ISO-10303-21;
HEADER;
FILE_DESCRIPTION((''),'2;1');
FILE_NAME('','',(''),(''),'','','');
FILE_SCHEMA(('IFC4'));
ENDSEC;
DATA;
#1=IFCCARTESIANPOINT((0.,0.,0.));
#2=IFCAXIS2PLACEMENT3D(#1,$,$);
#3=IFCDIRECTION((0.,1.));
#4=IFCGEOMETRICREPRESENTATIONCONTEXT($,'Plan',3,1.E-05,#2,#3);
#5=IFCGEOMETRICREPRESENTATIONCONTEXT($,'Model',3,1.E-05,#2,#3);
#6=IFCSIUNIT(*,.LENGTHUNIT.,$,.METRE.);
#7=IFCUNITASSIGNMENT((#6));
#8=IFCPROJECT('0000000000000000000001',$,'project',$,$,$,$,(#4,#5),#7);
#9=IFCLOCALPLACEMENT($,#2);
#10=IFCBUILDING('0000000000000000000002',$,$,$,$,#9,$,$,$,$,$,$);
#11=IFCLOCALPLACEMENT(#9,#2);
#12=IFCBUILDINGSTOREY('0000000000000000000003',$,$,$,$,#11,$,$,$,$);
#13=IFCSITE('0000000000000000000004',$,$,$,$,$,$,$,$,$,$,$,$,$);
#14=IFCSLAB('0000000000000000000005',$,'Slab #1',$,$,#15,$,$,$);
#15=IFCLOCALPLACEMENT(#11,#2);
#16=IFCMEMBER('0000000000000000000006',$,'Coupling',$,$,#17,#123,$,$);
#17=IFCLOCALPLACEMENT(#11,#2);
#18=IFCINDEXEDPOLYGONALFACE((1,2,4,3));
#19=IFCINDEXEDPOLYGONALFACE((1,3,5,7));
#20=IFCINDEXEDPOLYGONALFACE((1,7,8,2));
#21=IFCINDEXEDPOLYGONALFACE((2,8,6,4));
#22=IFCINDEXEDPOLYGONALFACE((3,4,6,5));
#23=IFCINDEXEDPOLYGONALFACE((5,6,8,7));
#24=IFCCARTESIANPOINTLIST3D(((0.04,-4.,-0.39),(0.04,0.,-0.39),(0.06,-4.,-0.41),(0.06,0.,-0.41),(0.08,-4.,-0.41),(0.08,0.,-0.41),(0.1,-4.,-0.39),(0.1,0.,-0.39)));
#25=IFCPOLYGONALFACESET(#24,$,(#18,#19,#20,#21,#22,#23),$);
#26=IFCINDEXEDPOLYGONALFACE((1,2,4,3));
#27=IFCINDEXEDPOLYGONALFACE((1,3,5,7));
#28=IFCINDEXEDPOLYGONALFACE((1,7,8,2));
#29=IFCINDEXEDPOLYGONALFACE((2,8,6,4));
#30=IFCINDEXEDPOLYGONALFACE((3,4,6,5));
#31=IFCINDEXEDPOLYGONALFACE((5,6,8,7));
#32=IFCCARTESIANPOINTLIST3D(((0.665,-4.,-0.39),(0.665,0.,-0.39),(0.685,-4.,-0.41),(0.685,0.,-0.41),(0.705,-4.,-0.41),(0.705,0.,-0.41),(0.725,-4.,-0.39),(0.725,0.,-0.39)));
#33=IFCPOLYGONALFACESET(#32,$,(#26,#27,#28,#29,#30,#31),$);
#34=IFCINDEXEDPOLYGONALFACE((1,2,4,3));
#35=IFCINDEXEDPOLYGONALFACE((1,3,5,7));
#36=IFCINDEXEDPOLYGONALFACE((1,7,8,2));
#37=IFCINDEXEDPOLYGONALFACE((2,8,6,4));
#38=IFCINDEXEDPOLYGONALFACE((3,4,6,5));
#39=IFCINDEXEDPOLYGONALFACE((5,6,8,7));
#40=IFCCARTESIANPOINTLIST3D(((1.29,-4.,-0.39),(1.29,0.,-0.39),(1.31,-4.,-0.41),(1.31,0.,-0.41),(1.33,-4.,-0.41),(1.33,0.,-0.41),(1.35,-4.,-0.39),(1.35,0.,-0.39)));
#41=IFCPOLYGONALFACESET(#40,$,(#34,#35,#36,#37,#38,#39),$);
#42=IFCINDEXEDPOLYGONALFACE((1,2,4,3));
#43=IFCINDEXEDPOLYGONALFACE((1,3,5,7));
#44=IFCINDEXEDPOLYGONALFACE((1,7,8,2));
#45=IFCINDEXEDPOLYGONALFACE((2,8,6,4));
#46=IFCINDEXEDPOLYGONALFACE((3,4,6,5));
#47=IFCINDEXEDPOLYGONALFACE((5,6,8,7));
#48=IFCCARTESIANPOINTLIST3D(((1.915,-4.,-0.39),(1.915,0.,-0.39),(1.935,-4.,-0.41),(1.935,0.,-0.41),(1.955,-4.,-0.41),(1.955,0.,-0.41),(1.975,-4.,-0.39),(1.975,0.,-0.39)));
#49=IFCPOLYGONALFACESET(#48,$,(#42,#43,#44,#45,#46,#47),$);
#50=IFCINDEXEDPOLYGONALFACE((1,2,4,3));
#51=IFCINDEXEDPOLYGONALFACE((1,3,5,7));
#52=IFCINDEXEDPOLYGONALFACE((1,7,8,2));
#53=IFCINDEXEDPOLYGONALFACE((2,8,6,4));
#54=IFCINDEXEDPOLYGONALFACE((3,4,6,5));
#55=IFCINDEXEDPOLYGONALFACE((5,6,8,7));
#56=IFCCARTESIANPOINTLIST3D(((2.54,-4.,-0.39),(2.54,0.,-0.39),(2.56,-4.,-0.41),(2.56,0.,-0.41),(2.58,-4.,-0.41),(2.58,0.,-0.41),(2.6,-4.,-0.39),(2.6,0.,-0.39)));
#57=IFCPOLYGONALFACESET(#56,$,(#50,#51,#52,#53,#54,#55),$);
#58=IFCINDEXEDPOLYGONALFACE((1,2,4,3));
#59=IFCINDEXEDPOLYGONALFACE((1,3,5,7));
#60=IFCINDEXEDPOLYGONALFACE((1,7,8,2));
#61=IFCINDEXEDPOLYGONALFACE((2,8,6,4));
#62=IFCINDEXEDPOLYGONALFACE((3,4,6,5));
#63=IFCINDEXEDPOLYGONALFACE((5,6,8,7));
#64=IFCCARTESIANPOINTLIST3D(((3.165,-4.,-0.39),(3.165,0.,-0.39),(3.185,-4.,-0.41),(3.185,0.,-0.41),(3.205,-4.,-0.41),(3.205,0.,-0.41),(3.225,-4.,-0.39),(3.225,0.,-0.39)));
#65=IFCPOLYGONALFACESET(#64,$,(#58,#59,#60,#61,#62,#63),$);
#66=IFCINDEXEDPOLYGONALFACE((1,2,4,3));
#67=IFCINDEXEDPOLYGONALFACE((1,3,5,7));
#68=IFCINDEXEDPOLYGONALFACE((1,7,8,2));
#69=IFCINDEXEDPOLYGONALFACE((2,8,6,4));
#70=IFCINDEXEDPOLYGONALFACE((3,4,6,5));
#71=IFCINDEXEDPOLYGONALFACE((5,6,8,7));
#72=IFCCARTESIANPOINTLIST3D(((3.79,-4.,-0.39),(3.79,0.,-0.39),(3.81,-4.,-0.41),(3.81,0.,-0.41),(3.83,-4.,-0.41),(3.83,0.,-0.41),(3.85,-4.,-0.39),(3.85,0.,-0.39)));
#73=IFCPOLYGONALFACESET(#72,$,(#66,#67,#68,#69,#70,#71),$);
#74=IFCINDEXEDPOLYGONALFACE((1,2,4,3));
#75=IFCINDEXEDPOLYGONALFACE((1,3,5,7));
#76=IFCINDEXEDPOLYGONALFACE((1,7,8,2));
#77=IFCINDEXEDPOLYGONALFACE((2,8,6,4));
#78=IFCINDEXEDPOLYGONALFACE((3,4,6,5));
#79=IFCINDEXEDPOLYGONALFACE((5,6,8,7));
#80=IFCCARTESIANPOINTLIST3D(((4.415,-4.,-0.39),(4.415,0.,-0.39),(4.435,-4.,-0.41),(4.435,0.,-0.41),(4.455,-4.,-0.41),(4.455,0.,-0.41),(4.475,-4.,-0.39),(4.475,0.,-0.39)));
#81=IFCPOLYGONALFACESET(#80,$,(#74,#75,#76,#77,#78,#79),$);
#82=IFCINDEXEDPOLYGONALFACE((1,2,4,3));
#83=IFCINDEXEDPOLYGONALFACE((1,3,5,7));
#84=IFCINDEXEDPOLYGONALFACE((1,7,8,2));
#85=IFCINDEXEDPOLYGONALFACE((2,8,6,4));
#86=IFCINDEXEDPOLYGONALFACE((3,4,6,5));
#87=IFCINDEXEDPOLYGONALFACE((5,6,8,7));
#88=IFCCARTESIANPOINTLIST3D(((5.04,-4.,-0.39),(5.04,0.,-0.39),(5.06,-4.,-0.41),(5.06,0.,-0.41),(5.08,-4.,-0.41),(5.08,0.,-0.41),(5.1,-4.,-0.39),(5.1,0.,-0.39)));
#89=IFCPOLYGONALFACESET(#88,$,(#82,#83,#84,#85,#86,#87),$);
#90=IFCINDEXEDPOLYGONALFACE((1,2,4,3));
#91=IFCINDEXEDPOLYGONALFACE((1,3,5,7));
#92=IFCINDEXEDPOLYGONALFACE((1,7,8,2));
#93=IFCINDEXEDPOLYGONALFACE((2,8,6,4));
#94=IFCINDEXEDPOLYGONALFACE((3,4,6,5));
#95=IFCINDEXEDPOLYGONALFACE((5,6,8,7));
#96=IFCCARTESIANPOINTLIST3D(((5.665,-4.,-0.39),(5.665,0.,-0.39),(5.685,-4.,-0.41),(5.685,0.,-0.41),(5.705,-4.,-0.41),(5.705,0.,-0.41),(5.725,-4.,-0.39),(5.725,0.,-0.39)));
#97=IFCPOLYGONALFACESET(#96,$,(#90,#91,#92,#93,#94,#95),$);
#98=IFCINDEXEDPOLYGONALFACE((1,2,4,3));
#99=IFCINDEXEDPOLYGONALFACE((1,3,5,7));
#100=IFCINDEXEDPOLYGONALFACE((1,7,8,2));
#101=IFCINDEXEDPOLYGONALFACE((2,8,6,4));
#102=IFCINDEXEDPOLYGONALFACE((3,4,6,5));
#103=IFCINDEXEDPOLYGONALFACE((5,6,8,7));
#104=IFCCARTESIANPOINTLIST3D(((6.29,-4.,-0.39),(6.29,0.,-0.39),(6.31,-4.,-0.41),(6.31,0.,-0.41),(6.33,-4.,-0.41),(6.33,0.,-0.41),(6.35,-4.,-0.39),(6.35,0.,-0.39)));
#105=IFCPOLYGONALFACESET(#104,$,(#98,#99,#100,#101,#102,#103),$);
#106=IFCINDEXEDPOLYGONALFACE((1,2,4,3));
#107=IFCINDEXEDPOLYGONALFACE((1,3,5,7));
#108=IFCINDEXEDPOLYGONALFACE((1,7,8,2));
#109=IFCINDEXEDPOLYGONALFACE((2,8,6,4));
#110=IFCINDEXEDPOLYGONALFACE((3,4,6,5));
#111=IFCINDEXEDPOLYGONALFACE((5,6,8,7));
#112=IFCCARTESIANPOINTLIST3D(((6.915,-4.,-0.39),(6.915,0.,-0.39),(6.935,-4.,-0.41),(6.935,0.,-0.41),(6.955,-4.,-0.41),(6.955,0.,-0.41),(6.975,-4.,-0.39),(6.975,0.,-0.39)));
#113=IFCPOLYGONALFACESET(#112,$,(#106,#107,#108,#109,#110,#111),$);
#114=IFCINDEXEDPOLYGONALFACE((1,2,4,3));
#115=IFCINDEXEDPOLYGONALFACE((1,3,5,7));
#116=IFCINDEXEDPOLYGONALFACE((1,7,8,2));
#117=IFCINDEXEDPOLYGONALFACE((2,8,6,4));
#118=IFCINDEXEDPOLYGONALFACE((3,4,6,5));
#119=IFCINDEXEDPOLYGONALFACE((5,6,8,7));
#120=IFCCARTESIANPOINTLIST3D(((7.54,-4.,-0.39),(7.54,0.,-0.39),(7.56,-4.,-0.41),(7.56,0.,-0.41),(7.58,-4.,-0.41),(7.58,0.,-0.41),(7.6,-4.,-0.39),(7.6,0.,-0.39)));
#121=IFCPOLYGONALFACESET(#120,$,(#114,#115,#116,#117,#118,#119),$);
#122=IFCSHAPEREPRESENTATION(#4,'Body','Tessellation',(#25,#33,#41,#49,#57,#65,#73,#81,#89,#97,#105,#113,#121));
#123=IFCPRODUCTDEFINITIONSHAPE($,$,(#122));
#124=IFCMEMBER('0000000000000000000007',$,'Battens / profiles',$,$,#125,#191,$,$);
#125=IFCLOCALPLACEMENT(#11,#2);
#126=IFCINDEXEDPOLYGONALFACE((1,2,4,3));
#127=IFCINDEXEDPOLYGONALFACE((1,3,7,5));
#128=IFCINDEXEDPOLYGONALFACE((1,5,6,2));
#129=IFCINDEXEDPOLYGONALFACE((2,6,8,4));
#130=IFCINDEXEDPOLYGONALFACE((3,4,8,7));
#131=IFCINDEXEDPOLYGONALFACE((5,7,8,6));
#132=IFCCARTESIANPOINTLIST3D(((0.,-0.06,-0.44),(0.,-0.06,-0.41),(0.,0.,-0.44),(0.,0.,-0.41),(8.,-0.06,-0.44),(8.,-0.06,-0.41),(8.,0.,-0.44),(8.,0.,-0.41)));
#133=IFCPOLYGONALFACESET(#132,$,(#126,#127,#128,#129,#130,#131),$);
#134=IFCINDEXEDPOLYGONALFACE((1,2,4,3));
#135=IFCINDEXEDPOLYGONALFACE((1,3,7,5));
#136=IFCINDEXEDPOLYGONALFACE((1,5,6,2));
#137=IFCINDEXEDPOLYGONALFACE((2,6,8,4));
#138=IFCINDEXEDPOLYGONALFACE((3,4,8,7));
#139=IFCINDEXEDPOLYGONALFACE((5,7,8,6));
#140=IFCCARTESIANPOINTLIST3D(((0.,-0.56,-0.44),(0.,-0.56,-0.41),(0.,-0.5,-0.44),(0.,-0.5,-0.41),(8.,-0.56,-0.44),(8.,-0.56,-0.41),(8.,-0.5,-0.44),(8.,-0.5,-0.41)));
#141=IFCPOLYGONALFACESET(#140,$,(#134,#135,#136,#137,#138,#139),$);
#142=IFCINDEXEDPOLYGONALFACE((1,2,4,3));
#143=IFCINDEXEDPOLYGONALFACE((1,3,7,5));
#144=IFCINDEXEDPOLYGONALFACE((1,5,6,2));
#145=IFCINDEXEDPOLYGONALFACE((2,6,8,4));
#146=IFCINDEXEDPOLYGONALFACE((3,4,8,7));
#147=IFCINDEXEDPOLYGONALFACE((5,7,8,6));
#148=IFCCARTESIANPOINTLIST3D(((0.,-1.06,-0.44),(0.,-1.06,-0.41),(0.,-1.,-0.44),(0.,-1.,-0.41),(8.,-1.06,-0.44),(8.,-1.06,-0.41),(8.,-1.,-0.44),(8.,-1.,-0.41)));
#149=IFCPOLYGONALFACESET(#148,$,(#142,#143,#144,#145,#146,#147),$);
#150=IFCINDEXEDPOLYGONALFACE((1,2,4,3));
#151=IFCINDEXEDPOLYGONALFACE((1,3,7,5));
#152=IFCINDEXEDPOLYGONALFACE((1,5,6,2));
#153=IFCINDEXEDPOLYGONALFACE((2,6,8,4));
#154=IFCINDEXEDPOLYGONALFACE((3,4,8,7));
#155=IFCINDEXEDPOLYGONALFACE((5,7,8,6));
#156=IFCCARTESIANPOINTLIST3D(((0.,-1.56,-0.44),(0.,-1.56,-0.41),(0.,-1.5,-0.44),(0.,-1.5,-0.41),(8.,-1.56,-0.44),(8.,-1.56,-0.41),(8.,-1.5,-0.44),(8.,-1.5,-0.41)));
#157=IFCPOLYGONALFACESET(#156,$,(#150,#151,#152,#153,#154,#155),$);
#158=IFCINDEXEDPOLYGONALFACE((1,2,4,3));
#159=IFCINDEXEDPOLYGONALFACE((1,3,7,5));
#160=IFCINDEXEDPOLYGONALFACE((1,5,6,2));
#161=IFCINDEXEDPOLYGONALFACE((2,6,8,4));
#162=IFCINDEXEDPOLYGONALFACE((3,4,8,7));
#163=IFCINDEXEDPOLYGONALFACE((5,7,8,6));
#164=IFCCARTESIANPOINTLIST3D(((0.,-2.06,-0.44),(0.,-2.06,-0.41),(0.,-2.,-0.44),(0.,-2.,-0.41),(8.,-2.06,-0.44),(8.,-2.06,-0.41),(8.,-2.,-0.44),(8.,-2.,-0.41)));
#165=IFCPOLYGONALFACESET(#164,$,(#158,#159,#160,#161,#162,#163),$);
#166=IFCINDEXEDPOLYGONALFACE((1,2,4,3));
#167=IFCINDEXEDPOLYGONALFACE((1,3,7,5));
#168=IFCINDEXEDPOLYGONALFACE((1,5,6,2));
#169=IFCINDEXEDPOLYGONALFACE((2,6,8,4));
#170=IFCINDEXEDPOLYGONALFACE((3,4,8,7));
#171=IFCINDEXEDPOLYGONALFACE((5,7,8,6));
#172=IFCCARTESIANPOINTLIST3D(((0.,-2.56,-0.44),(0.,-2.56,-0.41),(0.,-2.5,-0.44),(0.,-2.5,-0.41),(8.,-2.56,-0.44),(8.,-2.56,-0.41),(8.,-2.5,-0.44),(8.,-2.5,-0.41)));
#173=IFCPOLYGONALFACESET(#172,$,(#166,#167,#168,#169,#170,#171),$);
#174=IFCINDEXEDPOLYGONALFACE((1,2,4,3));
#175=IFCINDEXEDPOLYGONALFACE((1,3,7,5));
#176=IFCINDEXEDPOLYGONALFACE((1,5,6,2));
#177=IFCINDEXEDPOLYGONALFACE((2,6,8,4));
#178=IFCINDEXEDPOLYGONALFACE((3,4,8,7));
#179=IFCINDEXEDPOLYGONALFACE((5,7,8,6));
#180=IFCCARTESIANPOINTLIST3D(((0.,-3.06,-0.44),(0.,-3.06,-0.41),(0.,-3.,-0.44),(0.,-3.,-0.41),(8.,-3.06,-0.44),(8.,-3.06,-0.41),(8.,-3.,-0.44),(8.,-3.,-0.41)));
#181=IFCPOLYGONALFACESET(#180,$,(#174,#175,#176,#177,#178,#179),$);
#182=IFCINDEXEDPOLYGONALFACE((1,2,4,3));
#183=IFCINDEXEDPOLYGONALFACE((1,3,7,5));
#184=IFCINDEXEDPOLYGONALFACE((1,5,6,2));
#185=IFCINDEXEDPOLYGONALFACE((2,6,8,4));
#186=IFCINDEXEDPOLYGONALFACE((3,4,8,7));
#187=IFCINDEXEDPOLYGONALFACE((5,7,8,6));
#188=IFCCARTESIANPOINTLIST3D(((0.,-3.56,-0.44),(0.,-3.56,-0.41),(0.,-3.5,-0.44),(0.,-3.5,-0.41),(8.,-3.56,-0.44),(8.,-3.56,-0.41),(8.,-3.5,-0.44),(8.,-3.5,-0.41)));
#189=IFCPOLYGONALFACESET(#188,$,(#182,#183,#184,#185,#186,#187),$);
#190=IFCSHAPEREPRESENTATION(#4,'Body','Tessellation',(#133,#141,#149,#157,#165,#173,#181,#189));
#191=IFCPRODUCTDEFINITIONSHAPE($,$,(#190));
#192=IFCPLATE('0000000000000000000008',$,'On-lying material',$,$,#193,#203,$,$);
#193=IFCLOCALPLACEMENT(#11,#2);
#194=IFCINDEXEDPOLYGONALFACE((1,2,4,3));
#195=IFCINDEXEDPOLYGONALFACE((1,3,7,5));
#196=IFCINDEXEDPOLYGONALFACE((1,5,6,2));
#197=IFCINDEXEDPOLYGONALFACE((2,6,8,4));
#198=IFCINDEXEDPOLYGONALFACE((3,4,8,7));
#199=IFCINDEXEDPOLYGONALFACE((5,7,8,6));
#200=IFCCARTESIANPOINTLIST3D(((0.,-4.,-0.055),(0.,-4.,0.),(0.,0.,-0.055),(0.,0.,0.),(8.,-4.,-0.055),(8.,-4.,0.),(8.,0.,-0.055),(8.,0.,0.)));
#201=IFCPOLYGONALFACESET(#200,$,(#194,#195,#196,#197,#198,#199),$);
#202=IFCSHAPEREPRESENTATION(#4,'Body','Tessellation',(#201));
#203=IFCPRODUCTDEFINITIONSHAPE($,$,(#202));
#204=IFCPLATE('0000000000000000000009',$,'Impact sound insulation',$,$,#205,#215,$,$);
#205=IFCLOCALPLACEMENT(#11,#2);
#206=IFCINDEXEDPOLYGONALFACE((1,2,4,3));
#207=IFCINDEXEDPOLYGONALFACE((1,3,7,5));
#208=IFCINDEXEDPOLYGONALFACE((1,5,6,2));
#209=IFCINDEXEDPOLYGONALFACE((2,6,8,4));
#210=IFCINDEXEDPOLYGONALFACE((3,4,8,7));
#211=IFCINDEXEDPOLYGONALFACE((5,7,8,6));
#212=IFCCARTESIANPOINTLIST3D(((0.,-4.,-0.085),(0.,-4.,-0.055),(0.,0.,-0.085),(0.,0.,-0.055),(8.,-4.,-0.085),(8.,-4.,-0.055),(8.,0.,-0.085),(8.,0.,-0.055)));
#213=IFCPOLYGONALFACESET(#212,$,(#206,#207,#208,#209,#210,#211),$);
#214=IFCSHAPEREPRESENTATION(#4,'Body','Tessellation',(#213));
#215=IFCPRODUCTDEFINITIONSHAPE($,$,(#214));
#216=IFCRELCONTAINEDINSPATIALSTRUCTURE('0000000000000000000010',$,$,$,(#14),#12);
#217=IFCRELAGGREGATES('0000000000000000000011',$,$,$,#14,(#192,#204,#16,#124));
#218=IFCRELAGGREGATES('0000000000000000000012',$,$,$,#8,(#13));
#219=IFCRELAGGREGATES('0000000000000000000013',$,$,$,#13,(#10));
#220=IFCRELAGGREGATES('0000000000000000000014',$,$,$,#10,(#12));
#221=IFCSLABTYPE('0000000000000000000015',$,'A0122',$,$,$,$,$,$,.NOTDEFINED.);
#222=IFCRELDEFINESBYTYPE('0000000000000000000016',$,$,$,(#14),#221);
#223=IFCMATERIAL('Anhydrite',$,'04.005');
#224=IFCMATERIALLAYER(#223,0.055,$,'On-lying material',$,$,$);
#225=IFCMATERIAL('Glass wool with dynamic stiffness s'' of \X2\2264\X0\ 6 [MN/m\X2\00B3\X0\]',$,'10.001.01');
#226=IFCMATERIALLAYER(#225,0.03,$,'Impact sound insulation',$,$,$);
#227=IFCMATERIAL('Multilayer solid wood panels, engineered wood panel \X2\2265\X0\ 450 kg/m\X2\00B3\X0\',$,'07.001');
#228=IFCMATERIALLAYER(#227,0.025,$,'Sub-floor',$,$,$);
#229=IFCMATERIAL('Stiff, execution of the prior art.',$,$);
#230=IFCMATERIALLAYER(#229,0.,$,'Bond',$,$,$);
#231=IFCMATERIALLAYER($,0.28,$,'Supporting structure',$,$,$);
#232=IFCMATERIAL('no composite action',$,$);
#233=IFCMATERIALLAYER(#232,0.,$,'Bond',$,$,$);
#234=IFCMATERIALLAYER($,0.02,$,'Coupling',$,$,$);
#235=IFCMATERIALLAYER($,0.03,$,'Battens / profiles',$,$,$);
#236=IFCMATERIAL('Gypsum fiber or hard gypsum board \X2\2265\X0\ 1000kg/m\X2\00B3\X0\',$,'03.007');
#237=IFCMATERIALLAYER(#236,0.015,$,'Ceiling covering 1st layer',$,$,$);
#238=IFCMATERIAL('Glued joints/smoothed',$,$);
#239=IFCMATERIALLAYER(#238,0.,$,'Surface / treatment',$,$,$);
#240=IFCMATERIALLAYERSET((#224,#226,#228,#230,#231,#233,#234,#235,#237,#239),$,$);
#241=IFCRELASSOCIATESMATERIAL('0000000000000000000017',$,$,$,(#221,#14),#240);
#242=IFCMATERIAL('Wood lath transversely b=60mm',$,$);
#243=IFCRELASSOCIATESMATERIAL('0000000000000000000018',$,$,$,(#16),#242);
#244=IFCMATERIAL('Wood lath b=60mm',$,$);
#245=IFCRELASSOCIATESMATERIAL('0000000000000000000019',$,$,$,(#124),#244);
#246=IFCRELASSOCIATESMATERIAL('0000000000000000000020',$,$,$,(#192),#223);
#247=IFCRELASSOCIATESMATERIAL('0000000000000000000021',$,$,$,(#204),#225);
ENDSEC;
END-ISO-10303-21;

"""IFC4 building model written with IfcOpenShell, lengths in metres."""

from ifc_helpers import new_model, si_unit, direction, frame, frame_2d, origin, origin_with_axes, place, context, project, spatial, polyline, rectangle, outline, extrude, material, layer, layer_set, type_object, element, aggregate, save


model = new_model("IFC4")

# Units and contexts
plan_context = context("Plan", 3, precision=1e-05, world=origin(), true_north=direction((0.0, 1.0)))
model_context = context("Model", 3, precision=1e-05, world=origin(), true_north=direction((0.0, 1.0)))
ifc_project = project(units=[si_unit("LENGTHUNIT", "METRE")], contexts=[plan_context, model_context])

# Site, building, storey
site = spatial("IfcSite", under=ifc_project)
building_placement = place(None, origin())
building = spatial("IfcBuilding", under=site, at=building_placement)
storey_placement = place(building_placement, origin())
storey = spatial("IfcBuildingStorey", under=building, at=storey_placement)

# Slab, members, plates
ifc_material_1 = material(Name="Anhydrite", Category="04.005")
ifc_layer_1 = layer(ifc_material_1, 0.055, Name="On-lying material")
ifc_material_2 = material(Name="Glass wool with dynamic stiffness s' of ≤ 6 [MN/m³]", Category="10.001.01")
ifc_layer_2 = layer(ifc_material_2, 0.03, Name="Impact sound insulation")
ifc_material_3 = material(Name="Multilayer solid wood panels, engineered wood panel ≥ 450 kg/m³", Category="07.001")
ifc_layer_3 = layer(ifc_material_3, 0.025, Name="Sub-floor")
ifc_material_4 = material(Name="Stiff, execution of the prior art.")
ifc_layer_4 = layer(ifc_material_4, 0.0, Name="Bond")
ifc_layer_5 = layer(None, 0.28, Name="Supporting structure")
ifc_material_5 = material(Name="no composite action")
ifc_layer_6 = layer(ifc_material_5, 0.0, Name="Bond")
ifc_layer_7 = layer(None, 0.02, Name="Coupling")
ifc_layer_8 = layer(None, 0.03, Name="Battens / profiles")
ifc_material_6 = material(Name="Gypsum fiber or hard gypsum board ≥ 1000kg/m³", Category="03.007")
ifc_layer_9 = layer(ifc_material_6, 0.015, Name="Ceiling covering 1st layer")
ifc_material_7 = material(Name="Glued joints/smoothed")
ifc_layer_10 = layer(ifc_material_7, 0.0, Name="Surface / treatment")
ifc_layer_set = layer_set([ifc_layer_1, ifc_layer_2, ifc_layer_3, ifc_layer_4, ifc_layer_5, ifc_layer_6, ifc_layer_7, ifc_layer_8, ifc_layer_9, ifc_layer_10])
slab_type = type_object("IfcSlabType", Name="A0122", PredefinedType="NOTDEFINED", material=ifc_layer_set)
slab_placement = place(None, frame((0.0, 0.0, 0.0), z_axis=(0.0, 0.0, -1.0), x_axis=(1.0, 0.0, 0.0)))
slab = element("IfcSlab", 1, at=slab_placement, inside=storey, type_object=slab_type, material=ifc_layer_set, Name="Slab #1")
ifc_material_8 = material(Name="Wood lath transversely b=60mm")
member_1_placement = place(slab_placement, origin())
member_1 = element("IfcMember", 2, at=member_1_placement, material=ifc_material_8, Name="Coupling", context=plan_context, shape_type="SweptSolid", body=[
    extrude(outline(polyline([(0.0, 0.0), (0.06, 0.0), (0.04, 0.02), (0.02, 0.02), (0.0, 0.0)])), frame((0.04, 4.0, 0.39), z_axis=(0.0, -1.0, 0.0), x_axis=(1.0, 0.0, 0.0)), (0.0, 0.0, 1.0), 4.0),
    extrude(outline(polyline([(0.0, 0.0), (0.06, 0.0), (0.04, 0.02), (0.02, 0.02), (0.0, 0.0)])), frame((0.665, 4.0, 0.39), z_axis=(0.0, -1.0, 0.0), x_axis=(1.0, 0.0, 0.0)), (0.0, 0.0, 1.0), 4.0),
    extrude(outline(polyline([(0.0, 0.0), (0.06, 0.0), (0.04, 0.02), (0.02, 0.02), (0.0, 0.0)])), frame((1.29, 4.0, 0.39), z_axis=(0.0, -1.0, 0.0), x_axis=(1.0, 0.0, 0.0)), (0.0, 0.0, 1.0), 4.0),
    extrude(outline(polyline([(0.0, 0.0), (0.06, 0.0), (0.04, 0.02), (0.02, 0.02), (0.0, 0.0)])), frame((1.915, 4.0, 0.39), z_axis=(0.0, -1.0, 0.0), x_axis=(1.0, 0.0, 0.0)), (0.0, 0.0, 1.0), 4.0),
    extrude(outline(polyline([(0.0, 0.0), (0.06, 0.0), (0.04, 0.02), (0.02, 0.02), (0.0, 0.0)])), frame((2.54, 4.0, 0.39), z_axis=(0.0, -1.0, 0.0), x_axis=(1.0, 0.0, 0.0)), (0.0, 0.0, 1.0), 4.0),
    extrude(outline(polyline([(0.0, 0.0), (0.06, 0.0), (0.04, 0.02), (0.02, 0.02), (0.0, 0.0)])), frame((3.165, 4.0, 0.39), z_axis=(0.0, -1.0, 0.0), x_axis=(1.0, 0.0, 0.0)), (0.0, 0.0, 1.0), 4.0),
    extrude(outline(polyline([(0.0, 0.0), (0.06, 0.0), (0.04, 0.02), (0.02, 0.02), (0.0, 0.0)])), frame((3.79, 4.0, 0.39), z_axis=(0.0, -1.0, 0.0), x_axis=(1.0, 0.0, 0.0)), (0.0, 0.0, 1.0), 4.0),
    extrude(outline(polyline([(0.0, 0.0), (0.06, 0.0), (0.04, 0.02), (0.02, 0.02), (0.0, 0.0)])), frame((4.415, 4.0, 0.39), z_axis=(0.0, -1.0, 0.0), x_axis=(1.0, 0.0, 0.0)), (0.0, 0.0, 1.0), 4.0),
    extrude(outline(polyline([(0.0, 0.0), (0.06, 0.0), (0.04, 0.02), (0.02, 0.02), (0.0, 0.0)])), frame((5.04, 4.0, 0.39), z_axis=(0.0, -1.0, 0.0), x_axis=(1.0, 0.0, 0.0)), (0.0, 0.0, 1.0), 4.0),
    extrude(outline(polyline([(0.0, 0.0), (0.06, 0.0), (0.04, 0.02), (0.02, 0.02), (0.0, 0.0)])), frame((5.665, 4.0, 0.39), z_axis=(0.0, -1.0, 0.0), x_axis=(1.0, 0.0, 0.0)), (0.0, 0.0, 1.0), 4.0),
    extrude(outline(polyline([(0.0, 0.0), (0.06, 0.0), (0.04, 0.02), (0.02, 0.02), (0.0, 0.0)])), frame((6.29, 4.0, 0.39), z_axis=(0.0, -1.0, 0.0), x_axis=(1.0, 0.0, 0.0)), (0.0, 0.0, 1.0), 4.0),
    extrude(outline(polyline([(0.0, 0.0), (0.06, 0.0), (0.04, 0.02), (0.02, 0.02), (0.0, 0.0)])), frame((6.915, 4.0, 0.39), z_axis=(0.0, -1.0, 0.0), x_axis=(1.0, 0.0, 0.0)), (0.0, 0.0, 1.0), 4.0),
    extrude(outline(polyline([(0.0, 0.0), (0.06, 0.0), (0.04, 0.02), (0.02, 0.02), (0.0, 0.0)])), frame((7.54, 4.0, 0.39), z_axis=(0.0, -1.0, 0.0), x_axis=(1.0, 0.0, 0.0)), (0.0, 0.0, 1.0), 4.0),
])
ifc_material_9 = material(Name="Wood lath b=60mm")
member_2_placement = place(slab_placement, origin())
member_2 = element("IfcMember", 3, at=member_2_placement, material=ifc_material_9, Name="Battens / profiles", context=plan_context, shape_type="SweptSolid", body=[
    extrude(rectangle(XDim=0.06, YDim=0.03, at=frame_2d((0.03, 0.015), x_axis=(1.0, 0.0))), frame((0.0, 0.0, 0.41), z_axis=(1.0, 0.0, 0.0), x_axis=(0.0, 1.0, 0.0)), (0.0, 0.0, 1.0), 8.0),
    extrude(rectangle(XDim=0.06, YDim=0.03, at=frame_2d((0.03, 0.015), x_axis=(1.0, 0.0))), frame((0.0, 0.5, 0.41), z_axis=(1.0, 0.0, 0.0), x_axis=(0.0, 1.0, 0.0)), (0.0, 0.0, 1.0), 8.0),
    extrude(rectangle(XDim=0.06, YDim=0.03, at=frame_2d((0.03, 0.015), x_axis=(1.0, 0.0))), frame((0.0, 1.0, 0.41), z_axis=(1.0, 0.0, 0.0), x_axis=(0.0, 1.0, 0.0)), (0.0, 0.0, 1.0), 8.0),
    extrude(rectangle(XDim=0.06, YDim=0.03, at=frame_2d((0.03, 0.015), x_axis=(1.0, 0.0))), frame((0.0, 1.5, 0.41), z_axis=(1.0, 0.0, 0.0), x_axis=(0.0, 1.0, 0.0)), (0.0, 0.0, 1.0), 8.0),
    extrude(rectangle(XDim=0.06, YDim=0.03, at=frame_2d((0.03, 0.015), x_axis=(1.0, 0.0))), frame((0.0, 2.0, 0.41), z_axis=(1.0, 0.0, 0.0), x_axis=(0.0, 1.0, 0.0)), (0.0, 0.0, 1.0), 8.0),
    extrude(rectangle(XDim=0.06, YDim=0.03, at=frame_2d((0.03, 0.015), x_axis=(1.0, 0.0))), frame((0.0, 2.5, 0.41), z_axis=(1.0, 0.0, 0.0), x_axis=(0.0, 1.0, 0.0)), (0.0, 0.0, 1.0), 8.0),
    extrude(rectangle(XDim=0.06, YDim=0.03, at=frame_2d((0.03, 0.015), x_axis=(1.0, 0.0))), frame((0.0, 3.0, 0.41), z_axis=(1.0, 0.0, 0.0), x_axis=(0.0, 1.0, 0.0)), (0.0, 0.0, 1.0), 8.0),
    extrude(rectangle(XDim=0.06, YDim=0.03, at=frame_2d((0.03, 0.015), x_axis=(1.0, 0.0))), frame((0.0, 3.5, 0.41), z_axis=(1.0, 0.0, 0.0), x_axis=(0.0, 1.0, 0.0)), (0.0, 0.0, 1.0), 8.0),
])
plate_1_placement = place(slab_placement, origin())
plate_1 = element("IfcPlate", 4, at=plate_1_placement, material=ifc_material_1, Name="On-lying material", context=plan_context, shape_type="SweptSolid", body=[
    extrude(rectangle(XDim=8.0, YDim=4.0, at=frame_2d((4.0, 2.0), x_axis=(1.0, 0.0))), origin_with_axes(), (0.0, 0.0, 1.0), 0.055),
])
plate_2_placement = place(slab_placement, origin())
plate_2 = element("IfcPlate", 5, at=plate_2_placement, material=ifc_material_2, Name="Impact sound insulation", context=plan_context, shape_type="SweptSolid", body=[
    extrude(rectangle(XDim=8.0, YDim=4.0, at=frame_2d((4.0, 2.0), x_axis=(1.0, 0.0))), frame((0.0, 0.0, 0.055), z_axis=(0.0, 0.0, 1.0), x_axis=(1.0, 0.0, 0.0)), (0.0, 0.0, 1.0), 0.03),
])
aggregate(slab, [plate_1, plate_2, member_1, member_2])

save(model, "model.ifc")
